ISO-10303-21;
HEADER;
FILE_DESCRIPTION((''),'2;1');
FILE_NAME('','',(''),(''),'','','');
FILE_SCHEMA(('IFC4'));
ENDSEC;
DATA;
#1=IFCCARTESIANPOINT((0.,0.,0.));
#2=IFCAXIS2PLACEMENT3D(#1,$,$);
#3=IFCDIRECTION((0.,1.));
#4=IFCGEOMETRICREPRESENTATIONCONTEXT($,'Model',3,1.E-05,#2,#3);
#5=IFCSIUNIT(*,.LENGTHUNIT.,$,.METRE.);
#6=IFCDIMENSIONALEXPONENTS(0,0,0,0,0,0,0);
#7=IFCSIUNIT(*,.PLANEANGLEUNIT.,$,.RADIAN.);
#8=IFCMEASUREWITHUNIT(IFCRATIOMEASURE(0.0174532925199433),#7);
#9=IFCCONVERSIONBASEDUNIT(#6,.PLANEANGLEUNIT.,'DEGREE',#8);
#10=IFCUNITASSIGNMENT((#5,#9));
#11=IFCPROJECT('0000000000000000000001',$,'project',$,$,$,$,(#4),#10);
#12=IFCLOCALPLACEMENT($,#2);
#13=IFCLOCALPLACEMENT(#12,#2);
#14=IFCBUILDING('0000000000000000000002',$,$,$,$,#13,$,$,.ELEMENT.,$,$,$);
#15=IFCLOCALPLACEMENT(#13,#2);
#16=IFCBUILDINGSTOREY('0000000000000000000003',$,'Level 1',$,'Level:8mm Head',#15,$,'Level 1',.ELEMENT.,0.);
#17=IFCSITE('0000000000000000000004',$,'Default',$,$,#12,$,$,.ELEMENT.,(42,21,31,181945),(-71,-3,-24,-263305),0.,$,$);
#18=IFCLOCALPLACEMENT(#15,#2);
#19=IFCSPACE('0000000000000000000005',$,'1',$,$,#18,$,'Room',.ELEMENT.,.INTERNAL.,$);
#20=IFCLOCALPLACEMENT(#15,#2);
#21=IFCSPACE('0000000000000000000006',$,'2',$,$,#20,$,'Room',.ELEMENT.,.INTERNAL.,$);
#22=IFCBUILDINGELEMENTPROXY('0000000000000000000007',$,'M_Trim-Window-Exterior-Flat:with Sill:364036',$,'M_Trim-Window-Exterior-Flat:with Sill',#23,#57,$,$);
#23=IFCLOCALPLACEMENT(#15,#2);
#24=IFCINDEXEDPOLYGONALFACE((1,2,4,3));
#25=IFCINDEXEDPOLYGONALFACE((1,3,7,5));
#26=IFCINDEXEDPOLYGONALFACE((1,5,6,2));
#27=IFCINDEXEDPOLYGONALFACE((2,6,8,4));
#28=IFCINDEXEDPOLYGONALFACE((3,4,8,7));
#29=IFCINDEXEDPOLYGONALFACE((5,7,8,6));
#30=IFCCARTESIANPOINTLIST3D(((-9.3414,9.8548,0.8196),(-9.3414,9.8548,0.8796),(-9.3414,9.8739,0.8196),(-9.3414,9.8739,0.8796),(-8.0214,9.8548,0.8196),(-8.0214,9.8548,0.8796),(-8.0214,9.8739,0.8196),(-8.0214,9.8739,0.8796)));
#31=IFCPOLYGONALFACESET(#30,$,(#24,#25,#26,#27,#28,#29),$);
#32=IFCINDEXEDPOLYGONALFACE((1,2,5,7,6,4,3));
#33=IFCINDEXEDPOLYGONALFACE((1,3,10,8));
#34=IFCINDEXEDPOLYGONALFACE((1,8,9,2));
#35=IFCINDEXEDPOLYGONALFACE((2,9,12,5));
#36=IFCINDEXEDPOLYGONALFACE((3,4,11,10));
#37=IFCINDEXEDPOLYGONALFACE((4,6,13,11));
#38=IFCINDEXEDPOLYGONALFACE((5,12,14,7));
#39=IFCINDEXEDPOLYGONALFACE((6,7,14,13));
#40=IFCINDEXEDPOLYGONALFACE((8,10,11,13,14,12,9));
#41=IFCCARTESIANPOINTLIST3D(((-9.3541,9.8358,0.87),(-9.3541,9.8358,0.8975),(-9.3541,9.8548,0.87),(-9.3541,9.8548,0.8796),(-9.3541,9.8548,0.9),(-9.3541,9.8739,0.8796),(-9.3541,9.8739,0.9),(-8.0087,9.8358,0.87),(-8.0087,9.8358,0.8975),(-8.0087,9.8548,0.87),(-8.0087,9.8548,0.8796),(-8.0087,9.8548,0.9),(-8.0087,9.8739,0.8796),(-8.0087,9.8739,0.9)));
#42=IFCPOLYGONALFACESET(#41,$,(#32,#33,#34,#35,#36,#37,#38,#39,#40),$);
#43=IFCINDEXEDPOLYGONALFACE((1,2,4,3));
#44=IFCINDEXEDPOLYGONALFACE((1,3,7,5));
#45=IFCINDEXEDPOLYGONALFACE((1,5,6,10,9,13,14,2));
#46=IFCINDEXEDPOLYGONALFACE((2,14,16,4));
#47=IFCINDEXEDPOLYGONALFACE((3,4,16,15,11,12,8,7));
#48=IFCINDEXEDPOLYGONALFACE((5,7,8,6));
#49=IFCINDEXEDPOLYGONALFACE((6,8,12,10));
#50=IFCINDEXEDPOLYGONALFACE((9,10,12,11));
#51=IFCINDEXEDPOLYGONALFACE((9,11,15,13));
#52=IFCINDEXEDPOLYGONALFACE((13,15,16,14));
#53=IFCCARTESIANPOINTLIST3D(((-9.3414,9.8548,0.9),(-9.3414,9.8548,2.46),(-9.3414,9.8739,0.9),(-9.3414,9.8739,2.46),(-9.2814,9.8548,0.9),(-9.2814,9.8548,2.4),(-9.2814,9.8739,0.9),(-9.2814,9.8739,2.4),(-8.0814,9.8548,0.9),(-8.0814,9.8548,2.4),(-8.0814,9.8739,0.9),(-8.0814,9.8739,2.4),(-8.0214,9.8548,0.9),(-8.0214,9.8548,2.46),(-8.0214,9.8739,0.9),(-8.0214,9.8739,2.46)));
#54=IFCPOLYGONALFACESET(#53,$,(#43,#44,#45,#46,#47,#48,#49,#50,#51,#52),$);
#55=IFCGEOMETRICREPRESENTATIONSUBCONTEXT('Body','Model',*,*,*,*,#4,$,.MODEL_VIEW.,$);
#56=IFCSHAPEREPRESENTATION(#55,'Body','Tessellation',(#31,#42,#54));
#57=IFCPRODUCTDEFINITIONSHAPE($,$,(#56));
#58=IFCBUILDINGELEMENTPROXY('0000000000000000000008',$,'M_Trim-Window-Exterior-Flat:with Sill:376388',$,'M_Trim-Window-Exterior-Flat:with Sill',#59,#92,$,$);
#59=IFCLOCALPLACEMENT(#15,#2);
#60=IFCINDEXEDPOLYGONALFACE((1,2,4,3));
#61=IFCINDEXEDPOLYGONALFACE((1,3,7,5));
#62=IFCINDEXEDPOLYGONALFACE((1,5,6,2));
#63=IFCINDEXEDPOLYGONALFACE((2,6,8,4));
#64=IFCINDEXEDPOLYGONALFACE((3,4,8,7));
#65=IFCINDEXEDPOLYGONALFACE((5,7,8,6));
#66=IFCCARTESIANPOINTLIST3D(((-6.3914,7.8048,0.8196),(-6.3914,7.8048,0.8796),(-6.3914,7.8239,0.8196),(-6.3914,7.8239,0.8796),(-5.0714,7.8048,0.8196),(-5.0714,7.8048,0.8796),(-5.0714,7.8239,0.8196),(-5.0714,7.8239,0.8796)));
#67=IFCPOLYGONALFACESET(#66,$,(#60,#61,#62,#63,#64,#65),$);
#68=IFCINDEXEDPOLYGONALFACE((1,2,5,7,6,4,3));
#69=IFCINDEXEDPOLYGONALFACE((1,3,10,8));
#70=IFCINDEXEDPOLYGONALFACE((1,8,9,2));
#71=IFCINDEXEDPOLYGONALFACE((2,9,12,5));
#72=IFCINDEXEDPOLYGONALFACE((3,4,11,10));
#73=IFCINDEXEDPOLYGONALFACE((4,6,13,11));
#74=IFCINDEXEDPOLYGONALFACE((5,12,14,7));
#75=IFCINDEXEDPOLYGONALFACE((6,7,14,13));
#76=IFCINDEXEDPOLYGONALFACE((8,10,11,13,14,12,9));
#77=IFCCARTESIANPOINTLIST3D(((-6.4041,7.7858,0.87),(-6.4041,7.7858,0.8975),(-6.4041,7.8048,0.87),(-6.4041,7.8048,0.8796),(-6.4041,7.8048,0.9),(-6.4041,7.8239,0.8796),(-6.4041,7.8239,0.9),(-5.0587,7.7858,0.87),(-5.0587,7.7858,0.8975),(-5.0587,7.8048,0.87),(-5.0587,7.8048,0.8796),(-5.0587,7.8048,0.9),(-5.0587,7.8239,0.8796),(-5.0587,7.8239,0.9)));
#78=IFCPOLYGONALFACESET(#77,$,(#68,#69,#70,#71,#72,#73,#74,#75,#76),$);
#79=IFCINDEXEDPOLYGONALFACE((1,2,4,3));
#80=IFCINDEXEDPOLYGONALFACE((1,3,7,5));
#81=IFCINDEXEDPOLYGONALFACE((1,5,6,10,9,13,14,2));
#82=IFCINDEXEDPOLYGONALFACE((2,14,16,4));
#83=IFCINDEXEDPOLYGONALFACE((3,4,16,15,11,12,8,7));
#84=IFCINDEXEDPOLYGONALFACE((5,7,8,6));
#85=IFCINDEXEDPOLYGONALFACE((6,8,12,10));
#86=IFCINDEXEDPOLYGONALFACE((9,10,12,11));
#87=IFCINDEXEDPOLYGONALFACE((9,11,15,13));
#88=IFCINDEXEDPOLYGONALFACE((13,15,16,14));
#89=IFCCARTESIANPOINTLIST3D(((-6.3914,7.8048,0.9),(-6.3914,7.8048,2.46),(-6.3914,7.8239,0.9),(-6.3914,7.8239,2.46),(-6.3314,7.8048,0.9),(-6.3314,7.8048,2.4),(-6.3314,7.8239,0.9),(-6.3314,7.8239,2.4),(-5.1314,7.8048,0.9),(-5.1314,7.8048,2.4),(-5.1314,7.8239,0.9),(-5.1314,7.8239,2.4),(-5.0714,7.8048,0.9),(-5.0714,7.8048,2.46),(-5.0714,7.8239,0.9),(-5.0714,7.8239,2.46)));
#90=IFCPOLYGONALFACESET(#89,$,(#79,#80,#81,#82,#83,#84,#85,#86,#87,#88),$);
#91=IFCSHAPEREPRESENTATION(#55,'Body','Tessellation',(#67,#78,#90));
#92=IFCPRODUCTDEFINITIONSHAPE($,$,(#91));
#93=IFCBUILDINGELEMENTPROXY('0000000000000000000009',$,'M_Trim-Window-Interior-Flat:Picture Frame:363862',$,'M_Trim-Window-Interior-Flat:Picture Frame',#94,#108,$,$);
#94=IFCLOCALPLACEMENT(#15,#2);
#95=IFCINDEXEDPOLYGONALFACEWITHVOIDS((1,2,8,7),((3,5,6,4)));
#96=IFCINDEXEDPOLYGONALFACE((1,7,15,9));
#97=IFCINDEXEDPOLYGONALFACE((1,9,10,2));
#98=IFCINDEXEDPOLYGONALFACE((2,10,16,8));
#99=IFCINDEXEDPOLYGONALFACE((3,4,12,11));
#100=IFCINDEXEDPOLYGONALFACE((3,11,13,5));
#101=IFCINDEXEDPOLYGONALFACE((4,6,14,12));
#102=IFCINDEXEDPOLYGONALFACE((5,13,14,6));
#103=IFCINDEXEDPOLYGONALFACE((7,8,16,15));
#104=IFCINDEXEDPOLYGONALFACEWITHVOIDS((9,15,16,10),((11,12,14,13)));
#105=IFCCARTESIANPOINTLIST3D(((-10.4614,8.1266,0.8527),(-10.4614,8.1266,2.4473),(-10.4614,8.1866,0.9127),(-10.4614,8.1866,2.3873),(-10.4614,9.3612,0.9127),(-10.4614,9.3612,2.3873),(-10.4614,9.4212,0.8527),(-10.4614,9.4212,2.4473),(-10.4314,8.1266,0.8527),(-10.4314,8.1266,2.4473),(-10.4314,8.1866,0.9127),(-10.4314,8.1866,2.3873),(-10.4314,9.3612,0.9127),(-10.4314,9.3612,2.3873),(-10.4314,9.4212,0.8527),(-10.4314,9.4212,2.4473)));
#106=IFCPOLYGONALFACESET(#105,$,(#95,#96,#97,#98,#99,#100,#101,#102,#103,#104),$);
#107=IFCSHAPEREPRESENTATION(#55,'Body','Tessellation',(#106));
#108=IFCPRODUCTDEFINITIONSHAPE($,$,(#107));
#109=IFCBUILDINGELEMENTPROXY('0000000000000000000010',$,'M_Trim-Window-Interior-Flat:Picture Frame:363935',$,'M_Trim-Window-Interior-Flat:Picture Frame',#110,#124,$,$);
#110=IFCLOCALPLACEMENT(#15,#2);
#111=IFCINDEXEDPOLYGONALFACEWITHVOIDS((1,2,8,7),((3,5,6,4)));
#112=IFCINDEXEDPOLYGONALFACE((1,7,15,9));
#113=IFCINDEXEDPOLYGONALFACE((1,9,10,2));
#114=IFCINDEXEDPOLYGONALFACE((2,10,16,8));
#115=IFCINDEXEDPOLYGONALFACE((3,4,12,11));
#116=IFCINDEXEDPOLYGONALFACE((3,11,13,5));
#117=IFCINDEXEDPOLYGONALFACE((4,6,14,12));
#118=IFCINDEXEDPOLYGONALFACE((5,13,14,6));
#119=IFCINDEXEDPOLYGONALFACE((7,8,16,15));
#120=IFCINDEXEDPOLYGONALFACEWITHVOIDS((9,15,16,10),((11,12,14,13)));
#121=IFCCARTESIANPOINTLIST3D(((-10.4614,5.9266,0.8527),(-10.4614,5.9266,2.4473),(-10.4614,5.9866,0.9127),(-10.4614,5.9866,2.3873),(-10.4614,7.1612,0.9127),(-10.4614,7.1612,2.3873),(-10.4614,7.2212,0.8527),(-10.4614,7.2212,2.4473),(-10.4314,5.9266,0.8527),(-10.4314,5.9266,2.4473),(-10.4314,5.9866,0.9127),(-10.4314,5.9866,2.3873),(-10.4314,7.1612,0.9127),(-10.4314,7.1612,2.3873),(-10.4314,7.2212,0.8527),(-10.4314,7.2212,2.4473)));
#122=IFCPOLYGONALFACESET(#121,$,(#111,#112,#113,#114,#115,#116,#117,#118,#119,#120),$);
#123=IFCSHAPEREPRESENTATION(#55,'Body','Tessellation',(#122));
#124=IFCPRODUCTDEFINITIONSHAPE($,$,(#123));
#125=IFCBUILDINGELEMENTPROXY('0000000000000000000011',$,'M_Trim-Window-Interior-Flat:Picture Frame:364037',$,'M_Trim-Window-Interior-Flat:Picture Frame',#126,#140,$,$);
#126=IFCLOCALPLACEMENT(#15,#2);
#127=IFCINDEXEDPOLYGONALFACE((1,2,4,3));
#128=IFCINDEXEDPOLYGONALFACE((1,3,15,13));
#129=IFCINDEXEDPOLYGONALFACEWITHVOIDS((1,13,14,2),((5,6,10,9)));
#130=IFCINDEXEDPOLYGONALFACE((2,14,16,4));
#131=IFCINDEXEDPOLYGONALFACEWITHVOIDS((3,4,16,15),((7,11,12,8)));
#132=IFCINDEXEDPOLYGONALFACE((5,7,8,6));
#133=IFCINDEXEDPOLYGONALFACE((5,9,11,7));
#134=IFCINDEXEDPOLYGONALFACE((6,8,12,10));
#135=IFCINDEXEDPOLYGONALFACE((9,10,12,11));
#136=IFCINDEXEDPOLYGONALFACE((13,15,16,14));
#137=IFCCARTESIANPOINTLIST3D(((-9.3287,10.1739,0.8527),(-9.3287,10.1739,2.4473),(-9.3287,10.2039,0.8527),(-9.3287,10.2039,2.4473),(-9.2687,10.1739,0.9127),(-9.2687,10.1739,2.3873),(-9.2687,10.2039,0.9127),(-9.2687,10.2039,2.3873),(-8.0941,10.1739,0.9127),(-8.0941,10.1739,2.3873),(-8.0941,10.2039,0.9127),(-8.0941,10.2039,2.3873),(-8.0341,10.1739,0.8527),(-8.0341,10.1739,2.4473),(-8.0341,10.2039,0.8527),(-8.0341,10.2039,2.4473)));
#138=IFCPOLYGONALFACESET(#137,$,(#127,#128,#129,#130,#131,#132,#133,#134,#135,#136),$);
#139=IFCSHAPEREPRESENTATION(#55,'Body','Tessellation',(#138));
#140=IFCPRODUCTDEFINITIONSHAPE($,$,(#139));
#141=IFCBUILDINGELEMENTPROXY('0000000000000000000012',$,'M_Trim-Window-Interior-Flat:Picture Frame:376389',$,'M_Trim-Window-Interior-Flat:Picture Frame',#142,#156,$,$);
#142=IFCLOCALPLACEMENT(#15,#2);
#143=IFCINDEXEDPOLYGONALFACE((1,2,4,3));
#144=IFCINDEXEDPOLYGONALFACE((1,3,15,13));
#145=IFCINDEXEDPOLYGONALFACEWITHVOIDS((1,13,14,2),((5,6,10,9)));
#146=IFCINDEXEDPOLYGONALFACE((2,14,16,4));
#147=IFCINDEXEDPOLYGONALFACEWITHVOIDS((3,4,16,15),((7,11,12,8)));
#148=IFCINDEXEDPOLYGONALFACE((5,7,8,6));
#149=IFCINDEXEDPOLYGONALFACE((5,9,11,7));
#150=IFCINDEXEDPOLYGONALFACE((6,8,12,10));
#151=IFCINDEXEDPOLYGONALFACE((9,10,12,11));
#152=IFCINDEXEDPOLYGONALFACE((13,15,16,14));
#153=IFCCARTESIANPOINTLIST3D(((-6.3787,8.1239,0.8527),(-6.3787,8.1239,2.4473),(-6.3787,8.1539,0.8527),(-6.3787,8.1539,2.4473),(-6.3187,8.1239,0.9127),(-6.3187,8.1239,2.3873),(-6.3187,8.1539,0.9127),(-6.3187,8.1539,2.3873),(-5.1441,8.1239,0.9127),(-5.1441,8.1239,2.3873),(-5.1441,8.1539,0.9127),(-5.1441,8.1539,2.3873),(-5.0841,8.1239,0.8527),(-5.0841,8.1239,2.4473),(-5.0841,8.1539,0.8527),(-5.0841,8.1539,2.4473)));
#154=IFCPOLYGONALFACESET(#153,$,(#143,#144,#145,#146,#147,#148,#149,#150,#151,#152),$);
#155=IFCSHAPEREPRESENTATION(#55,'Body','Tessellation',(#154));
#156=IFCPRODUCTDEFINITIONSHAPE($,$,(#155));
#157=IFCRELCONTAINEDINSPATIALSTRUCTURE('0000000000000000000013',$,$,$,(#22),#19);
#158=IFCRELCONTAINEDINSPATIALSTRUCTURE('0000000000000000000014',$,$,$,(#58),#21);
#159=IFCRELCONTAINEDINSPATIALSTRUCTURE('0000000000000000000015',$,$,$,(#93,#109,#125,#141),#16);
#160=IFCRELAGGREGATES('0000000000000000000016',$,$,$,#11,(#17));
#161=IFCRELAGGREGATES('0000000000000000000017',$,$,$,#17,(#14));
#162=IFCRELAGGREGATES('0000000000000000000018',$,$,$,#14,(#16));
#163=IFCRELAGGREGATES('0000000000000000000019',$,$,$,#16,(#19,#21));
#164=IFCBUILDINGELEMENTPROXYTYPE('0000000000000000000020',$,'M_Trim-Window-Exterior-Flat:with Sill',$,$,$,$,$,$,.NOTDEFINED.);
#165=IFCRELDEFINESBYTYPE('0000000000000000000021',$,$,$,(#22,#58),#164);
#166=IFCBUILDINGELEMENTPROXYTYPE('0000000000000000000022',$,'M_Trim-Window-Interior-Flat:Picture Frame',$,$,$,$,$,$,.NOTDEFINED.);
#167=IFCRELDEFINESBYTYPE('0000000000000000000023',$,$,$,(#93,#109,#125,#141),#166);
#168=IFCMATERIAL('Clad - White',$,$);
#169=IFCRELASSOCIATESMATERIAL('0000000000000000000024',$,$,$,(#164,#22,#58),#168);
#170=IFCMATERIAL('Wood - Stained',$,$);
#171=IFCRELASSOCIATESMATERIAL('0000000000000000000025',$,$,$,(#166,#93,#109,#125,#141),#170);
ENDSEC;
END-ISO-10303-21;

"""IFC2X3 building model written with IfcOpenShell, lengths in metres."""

from ifc_helpers import new_model, entity, si_unit, converted_unit, direction, frame, frame_2d, origin, place, context, subcontext, project, spatial, polyline, rectangle, outline, extrude, source, transform, mapped, material, type_object, type_shapes, element, save


model = new_model("IFC2X3")

# Units and contexts
model_context = context("Model", 3, precision=1e-05, world=origin(), true_north=direction((0.0, 1.0)))
body_context = subcontext(model_context, "Body", "Model", "MODEL_VIEW")
ifc_project = project(units=[si_unit("LENGTHUNIT", "METRE"), converted_unit("PLANEANGLEUNIT", "DEGREE", entity("IfcRatioMeasure", 0.0174532925199433), si_unit("PLANEANGLEUNIT", "RADIAN"), dimensions=[0, 0, 0, 0, 0, 0, 0])], contexts=[model_context])

# Site, building, storey
site_placement = place(None, origin())
site = spatial("IfcSite", under=ifc_project, at=site_placement, Name="Default", CompositionType="ELEMENT", RefLatitude=(42, 21, 31, 181945), RefLongitude=(-71, -3, -24, -263305), RefElevation=0.0)
building_placement = place(site_placement, origin())
building = spatial("IfcBuilding", under=site, at=building_placement, CompositionType="ELEMENT")
storey_placement = place(building_placement, origin())
storey = spatial("IfcBuildingStorey", under=building, at=storey_placement, Name="Level 1", ObjectType="Level:8mm Head", LongName="Level 1", CompositionType="ELEMENT", Elevation=0.0)

# Shared definitions
ifc_material_1 = material(Name="Clad - White")
ifc_material_2 = material(Name="Wood - Stained")

# Shared definitions
space_1_placement = place(storey_placement, origin())
space_1 = spatial("IfcSpace", under=storey, at=space_1_placement, Name="1", LongName="Room", CompositionType="ELEMENT", InteriorOrExteriorSpace="INTERNAL")

# Building element proxy
building_element_proxy_type_1 = type_object("IfcBuildingElementProxyType", Name="M_Trim-Window-Exterior-Flat:with Sill", PredefinedType="NOTDEFINED", material=ifc_material_1)
shared_shape_1 = source(origin(), body_context, "Body", "SweptSolid", [
    extrude(rectangle(XDim=1.32, YDim=0.06, at=frame_2d((0.0, 0.0), x_axis=(1.0, 0.0))), frame((0.0, -1.5504, 0.0), z_axis=(0.0, 0.0, 1.0), x_axis=(-1.0, 0.0, 0.0)), (0.0, 0.0, 1.0), 0.0191),
    extrude(outline(polyline([(-0.019, -0.0152), (0.0, -0.0152), (0.0, -0.0057), (0.019, -0.0057), (0.019, 0.0148), (0.0, 0.0148), (-0.019, 0.0123), (-0.019, -0.0152)])), frame((-0.6727, -1.5148, 0.019), z_axis=(1.0, 0.0, 0.0), x_axis=(0.0, 0.0, -1.0)), (0.0, 0.0, 1.0), 1.3454),
    extrude(outline(polyline([(-0.795, -0.66), (0.765, -0.66), (0.765, -0.6), (-0.735, -0.6), (-0.735, 0.6), (0.765, 0.6), (0.765, 0.66), (-0.795, 0.66), (-0.795, -0.66)])), frame((0.0, -0.735, 0.0), z_axis=(0.0, 0.0, 1.0), x_axis=(0.0, -1.0, 0.0)), (0.0, 0.0, 1.0), 0.0191),
])
type_shapes(building_element_proxy_type_1, [shared_shape_1])
for number, where, z_axis, x_axis, name in (
    (1, (-8.6814, 9.8739, 2.4), (0.0, -1.0, 0.0), (1.0, 0.0, 0.0), "M_Trim-Window-Exterior-Flat:with Sill:364036"),
):
    element("IfcBuildingElementProxy", number, at=place(space_1_placement, frame(where, z_axis=z_axis, x_axis=x_axis)), inside=space_1, type_object=building_element_proxy_type_1, material=ifc_material_1, Name=name, ObjectType="M_Trim-Window-Exterior-Flat:with Sill", context=body_context, shape_type="MappedRepresentation", body=[
        mapped(shared_shape_1, transform((0.0, 0.0, 0.0), scale=1.0)),
    ])

# Shared definitions
space_2_placement = place(storey_placement, origin())
space_2 = spatial("IfcSpace", under=storey, at=space_2_placement, Name="2", LongName="Room", CompositionType="ELEMENT", InteriorOrExteriorSpace="INTERNAL")

# Building element proxies
proxy_1_placement = place(space_2_placement, frame((-5.7314, 7.8239, 2.4), z_axis=(0.0, -1.0, 0.0), x_axis=(1.0, 0.0, 0.0)))
element("IfcBuildingElementProxy", 2, at=proxy_1_placement, inside=space_2, type_object=building_element_proxy_type_1, material=ifc_material_1, Name="M_Trim-Window-Exterior-Flat:with Sill:376388", ObjectType="M_Trim-Window-Exterior-Flat:with Sill", context=body_context, shape_type="MappedRepresentation", body=[
    mapped(shared_shape_1, transform((0.0, 0.0, 0.0), scale=1.0)),
])
building_element_proxy_type_2 = type_object("IfcBuildingElementProxyType", Name="M_Trim-Window-Interior-Flat:Picture Frame", PredefinedType="NOTDEFINED", material=ifc_material_2)
shared_shape_2 = source(origin(), body_context, "Body", "SweptSolid", [
    extrude(outline(polyline([(-0.6473, -0.7973), (0.6473, -0.7973), (0.6473, 0.7973), (-0.6473, 0.7973), (-0.6473, -0.7973)]), holes=[polyline([(-0.5873, -0.7373), (-0.5873, 0.7373), (0.5873, 0.7373), (0.5873, -0.7373), (-0.5873, -0.7373)])]), frame((0.0, -0.75, 0.0), z_axis=(0.0, 0.0, 1.0), x_axis=(-1.0, 0.0, 0.0)), (0.0, 0.0, 1.0), 0.03),
])
type_shapes(building_element_proxy_type_2, [shared_shape_2])
for number, where, z_axis, x_axis, name in (
    (3, (-10.4314, 8.7739, 2.4), (-1.0, 0.0, 0.0), (0.0, -1.0, 0.0), "M_Trim-Window-Interior-Flat:Picture Frame:363862"),
    (4, (-10.4314, 6.5739, 2.4), (-1.0, 0.0, 0.0), (0.0, -1.0, 0.0), "M_Trim-Window-Interior-Flat:Picture Frame:363935"),
    (5, (-8.6814, 10.1739, 2.4), (0.0, 1.0, 0.0), (-1.0, 0.0, 0.0), "M_Trim-Window-Interior-Flat:Picture Frame:364037"),
    (6, (-5.7314, 8.1239, 2.4), (0.0, 1.0, 0.0), (-1.0, 0.0, 0.0), "M_Trim-Window-Interior-Flat:Picture Frame:376389"),
):
    element("IfcBuildingElementProxy", number, at=place(storey_placement, frame(where, z_axis=z_axis, x_axis=x_axis)), inside=storey, type_object=building_element_proxy_type_2, material=ifc_material_2, Name=name, ObjectType="M_Trim-Window-Interior-Flat:Picture Frame", context=body_context, shape_type="MappedRepresentation", body=[
        mapped(shared_shape_2, transform((0.0, 0.0, 0.0), scale=1.0)),
    ])

save(model, "model.ifc")
